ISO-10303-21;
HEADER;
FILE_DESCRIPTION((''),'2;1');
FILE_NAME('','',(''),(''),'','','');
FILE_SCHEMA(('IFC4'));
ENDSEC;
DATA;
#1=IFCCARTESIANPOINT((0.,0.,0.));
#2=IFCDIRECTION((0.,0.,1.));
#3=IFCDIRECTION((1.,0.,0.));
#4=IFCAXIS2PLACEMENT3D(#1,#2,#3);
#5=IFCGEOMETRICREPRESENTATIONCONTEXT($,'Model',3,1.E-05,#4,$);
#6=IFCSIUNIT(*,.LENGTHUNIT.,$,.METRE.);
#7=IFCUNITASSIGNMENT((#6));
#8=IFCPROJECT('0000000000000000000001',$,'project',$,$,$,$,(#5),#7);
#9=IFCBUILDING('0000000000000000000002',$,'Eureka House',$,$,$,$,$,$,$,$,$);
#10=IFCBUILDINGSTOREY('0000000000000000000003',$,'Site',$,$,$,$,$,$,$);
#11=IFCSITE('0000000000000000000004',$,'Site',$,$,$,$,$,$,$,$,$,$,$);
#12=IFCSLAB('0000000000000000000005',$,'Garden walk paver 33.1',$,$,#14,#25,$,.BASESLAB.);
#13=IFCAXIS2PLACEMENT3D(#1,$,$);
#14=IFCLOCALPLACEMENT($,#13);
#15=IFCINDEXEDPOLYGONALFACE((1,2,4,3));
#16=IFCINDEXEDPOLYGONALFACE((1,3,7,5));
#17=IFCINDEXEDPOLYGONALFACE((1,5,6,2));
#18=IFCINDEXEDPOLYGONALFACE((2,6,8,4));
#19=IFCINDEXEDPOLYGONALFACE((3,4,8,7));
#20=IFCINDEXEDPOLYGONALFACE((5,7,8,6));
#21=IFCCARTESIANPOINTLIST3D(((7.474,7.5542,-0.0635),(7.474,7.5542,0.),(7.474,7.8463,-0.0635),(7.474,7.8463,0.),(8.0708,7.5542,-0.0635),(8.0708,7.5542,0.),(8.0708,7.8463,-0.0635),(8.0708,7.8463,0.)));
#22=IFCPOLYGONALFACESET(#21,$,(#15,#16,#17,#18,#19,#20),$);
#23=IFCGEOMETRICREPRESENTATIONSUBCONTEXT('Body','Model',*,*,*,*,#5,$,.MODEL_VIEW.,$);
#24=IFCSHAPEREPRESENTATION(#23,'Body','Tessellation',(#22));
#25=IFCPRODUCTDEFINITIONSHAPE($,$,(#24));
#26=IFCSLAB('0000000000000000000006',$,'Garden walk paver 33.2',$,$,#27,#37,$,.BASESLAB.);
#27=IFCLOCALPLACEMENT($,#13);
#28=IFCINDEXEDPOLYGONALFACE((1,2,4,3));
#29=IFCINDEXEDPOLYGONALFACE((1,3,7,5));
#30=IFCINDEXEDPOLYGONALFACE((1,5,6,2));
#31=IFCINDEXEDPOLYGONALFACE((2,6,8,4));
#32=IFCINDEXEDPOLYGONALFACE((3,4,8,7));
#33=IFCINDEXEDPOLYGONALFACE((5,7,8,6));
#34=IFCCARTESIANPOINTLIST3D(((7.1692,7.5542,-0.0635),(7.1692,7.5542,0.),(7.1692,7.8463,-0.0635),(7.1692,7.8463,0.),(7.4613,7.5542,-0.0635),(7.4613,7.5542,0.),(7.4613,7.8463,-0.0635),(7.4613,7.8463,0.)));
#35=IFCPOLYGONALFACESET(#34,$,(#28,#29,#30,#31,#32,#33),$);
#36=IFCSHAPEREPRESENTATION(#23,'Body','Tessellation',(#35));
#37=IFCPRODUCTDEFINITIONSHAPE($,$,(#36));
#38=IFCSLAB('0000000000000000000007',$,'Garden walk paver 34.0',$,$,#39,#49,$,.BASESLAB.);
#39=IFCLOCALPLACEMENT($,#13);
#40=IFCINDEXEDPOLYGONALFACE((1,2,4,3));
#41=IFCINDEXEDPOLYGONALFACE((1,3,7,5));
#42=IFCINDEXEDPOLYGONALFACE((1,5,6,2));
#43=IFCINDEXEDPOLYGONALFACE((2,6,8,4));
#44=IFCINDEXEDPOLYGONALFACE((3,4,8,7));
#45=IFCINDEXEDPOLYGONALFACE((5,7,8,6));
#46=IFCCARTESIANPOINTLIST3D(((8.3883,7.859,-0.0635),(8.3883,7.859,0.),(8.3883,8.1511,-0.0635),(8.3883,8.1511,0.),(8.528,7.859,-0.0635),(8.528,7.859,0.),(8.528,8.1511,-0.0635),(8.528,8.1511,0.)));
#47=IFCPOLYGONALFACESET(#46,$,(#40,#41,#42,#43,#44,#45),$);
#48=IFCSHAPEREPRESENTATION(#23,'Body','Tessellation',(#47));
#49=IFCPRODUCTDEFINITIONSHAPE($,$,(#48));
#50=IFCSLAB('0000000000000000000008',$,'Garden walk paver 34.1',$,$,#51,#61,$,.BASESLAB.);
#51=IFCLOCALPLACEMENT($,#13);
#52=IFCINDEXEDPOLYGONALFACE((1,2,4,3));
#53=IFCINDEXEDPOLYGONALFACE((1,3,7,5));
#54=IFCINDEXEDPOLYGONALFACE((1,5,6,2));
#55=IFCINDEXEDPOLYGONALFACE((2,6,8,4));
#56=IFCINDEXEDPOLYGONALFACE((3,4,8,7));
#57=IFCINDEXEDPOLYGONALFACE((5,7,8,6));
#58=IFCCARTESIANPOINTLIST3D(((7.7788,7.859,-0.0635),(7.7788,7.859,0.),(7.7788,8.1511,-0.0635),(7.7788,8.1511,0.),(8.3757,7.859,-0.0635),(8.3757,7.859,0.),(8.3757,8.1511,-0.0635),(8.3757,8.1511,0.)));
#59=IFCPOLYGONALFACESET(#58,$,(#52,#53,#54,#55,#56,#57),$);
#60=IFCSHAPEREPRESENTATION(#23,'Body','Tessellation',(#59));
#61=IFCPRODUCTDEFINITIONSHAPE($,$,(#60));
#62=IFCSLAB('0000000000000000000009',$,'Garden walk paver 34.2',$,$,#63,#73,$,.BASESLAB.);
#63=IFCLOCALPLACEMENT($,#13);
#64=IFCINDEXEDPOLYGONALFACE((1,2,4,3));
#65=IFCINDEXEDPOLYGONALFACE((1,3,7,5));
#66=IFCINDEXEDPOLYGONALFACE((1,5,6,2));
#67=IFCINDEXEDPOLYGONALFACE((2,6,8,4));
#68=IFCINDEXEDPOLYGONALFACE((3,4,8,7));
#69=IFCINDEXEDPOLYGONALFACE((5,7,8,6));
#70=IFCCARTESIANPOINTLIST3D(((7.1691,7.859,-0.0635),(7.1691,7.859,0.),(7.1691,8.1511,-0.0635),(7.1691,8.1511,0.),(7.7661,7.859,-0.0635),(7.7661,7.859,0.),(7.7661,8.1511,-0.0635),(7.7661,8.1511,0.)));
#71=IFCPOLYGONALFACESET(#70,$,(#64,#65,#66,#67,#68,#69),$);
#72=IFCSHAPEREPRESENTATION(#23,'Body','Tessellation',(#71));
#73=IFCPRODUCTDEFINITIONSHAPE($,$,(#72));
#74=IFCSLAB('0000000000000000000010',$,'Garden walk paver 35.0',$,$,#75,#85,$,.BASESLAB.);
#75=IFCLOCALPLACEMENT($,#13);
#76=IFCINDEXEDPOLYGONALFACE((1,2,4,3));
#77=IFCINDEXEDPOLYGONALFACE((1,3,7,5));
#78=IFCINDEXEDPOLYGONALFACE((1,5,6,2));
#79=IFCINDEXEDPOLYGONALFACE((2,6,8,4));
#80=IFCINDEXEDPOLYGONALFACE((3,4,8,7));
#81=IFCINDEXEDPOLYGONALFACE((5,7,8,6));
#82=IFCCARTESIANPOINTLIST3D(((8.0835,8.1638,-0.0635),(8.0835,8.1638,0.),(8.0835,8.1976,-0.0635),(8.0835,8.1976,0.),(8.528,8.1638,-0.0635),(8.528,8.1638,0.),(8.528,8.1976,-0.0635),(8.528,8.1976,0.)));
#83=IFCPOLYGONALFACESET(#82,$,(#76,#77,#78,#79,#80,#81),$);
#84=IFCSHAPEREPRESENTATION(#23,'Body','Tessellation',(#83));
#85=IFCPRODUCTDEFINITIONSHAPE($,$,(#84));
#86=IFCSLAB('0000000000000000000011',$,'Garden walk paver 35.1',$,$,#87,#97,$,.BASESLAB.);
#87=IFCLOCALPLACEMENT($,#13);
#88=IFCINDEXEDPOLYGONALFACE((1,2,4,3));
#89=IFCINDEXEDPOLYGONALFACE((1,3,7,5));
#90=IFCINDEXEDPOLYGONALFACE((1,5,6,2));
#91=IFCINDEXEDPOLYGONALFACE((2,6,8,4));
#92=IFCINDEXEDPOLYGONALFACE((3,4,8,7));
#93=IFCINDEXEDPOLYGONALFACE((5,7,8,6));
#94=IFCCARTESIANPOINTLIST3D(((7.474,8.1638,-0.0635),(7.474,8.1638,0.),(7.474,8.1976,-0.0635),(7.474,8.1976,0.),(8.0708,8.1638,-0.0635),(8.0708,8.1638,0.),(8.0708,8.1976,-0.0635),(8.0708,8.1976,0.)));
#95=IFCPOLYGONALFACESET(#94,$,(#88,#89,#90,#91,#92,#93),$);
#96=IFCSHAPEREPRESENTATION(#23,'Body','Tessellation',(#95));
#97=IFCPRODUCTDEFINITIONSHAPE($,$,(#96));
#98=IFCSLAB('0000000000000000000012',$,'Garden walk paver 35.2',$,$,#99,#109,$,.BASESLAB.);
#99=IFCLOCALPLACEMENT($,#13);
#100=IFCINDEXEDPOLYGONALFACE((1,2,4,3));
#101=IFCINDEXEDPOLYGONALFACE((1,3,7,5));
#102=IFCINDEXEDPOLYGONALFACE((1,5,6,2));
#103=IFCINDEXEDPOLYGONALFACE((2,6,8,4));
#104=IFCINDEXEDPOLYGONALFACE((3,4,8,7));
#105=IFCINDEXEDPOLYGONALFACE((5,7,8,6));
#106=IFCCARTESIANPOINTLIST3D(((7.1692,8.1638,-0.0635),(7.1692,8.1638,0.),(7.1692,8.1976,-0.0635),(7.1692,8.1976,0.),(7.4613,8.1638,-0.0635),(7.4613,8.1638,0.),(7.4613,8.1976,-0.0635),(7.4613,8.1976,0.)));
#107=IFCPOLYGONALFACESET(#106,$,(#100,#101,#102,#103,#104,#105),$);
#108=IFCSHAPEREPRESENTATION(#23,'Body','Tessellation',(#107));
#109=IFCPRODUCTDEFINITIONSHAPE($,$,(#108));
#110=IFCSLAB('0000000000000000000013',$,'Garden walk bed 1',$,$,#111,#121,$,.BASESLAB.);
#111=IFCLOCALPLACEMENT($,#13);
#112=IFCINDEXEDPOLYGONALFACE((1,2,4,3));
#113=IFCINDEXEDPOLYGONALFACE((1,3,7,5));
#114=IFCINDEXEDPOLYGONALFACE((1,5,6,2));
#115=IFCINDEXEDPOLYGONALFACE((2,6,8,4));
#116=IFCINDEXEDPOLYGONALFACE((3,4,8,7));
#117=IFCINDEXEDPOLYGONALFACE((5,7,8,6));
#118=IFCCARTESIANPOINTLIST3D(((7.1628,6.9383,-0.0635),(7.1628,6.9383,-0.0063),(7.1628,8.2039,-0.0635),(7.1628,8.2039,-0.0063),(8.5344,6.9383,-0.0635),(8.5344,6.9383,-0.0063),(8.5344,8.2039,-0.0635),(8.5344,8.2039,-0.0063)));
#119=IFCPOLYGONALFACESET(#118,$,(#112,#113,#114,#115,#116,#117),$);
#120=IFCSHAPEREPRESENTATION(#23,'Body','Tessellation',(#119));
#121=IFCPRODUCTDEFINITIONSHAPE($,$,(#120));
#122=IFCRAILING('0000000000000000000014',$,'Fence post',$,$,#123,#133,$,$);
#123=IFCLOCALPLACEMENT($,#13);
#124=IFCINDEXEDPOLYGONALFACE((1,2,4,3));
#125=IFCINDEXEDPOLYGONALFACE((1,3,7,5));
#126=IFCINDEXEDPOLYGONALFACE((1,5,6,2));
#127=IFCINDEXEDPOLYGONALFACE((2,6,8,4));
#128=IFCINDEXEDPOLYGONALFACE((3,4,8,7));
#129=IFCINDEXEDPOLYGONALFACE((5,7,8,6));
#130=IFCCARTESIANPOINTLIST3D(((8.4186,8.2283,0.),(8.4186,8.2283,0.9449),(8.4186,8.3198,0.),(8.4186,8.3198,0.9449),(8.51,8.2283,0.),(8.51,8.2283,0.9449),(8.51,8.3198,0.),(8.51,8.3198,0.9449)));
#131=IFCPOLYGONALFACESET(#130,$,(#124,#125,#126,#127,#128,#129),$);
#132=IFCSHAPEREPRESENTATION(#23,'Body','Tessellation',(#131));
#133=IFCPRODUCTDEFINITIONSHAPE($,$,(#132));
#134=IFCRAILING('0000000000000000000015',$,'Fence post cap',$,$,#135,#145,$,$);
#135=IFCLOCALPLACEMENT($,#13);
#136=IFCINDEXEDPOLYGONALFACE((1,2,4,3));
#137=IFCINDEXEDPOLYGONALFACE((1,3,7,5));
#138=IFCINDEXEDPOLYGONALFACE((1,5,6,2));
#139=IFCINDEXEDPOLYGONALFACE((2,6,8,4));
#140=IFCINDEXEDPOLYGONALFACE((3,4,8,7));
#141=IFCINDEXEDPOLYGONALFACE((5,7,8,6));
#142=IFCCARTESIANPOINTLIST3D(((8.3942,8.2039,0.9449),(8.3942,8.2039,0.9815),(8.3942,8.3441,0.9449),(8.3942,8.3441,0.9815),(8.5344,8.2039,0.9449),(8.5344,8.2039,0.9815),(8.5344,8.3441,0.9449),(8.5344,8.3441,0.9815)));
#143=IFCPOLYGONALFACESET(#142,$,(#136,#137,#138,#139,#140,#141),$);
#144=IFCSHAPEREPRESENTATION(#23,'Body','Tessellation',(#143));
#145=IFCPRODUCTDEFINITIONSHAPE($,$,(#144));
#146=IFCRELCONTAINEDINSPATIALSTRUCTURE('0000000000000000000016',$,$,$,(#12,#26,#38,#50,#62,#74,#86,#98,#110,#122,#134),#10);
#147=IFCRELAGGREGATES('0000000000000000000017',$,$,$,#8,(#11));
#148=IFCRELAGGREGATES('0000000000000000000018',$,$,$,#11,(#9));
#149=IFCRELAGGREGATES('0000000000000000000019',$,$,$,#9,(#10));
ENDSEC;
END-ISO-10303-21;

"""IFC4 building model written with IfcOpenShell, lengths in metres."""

from ifc_helpers import new_model, si_unit, frame, origin, origin_with_axes, origin_2d, place, context, subcontext, project, spatial, rectangle, extrude, element, save


model = new_model("IFC4")

# Units and contexts
model_context = context("Model", 3, precision=1e-05, world=origin_with_axes())
body_context = subcontext(model_context, "Body", "Model", "MODEL_VIEW")
ifc_project = project(units=[si_unit("LENGTHUNIT", "METRE")], contexts=[model_context])

# Site, building, storey
site = spatial("IfcSite", under=ifc_project, Name="Site")
building = spatial("IfcBuilding", under=site, Name="Eureka House")
storey = spatial("IfcBuildingStorey", under=building, Name="Site")

# Slabs
slab_1_placement = place(None, frame((7.7724, 7.7003, -0.0635), z_axis=(0.0, 0.0, 1.0), x_axis=(1.0, 0.0, 0.0)))
element("IfcSlab", 1, at=slab_1_placement, inside=storey, Name="Garden walk paver 33.1", PredefinedType="BASESLAB", context=body_context, shape_type="SweptSolid", body=[
    extrude(rectangle(XDim=0.5969, YDim=0.2921, at=origin_2d()), origin(), (0.0, 0.0, 1.0), 0.0635),
])
slab_2_placement = place(None, frame((7.3152, 7.7003, -0.0635), z_axis=(0.0, 0.0, 1.0), x_axis=(1.0, 0.0, 0.0)))
element("IfcSlab", 2, at=slab_2_placement, inside=storey, Name="Garden walk paver 33.2", PredefinedType="BASESLAB", context=body_context, shape_type="SweptSolid", body=[
    extrude(rectangle(XDim=0.2921, YDim=0.2921, at=origin_2d()), origin(), (0.0, 0.0, 1.0), 0.0635),
])
slab_3_placement = place(None, frame((8.4582, 8.0051, -0.0635), z_axis=(0.0, 0.0, 1.0), x_axis=(1.0, 0.0, 0.0)))
element("IfcSlab", 3, at=slab_3_placement, inside=storey, Name="Garden walk paver 34.0", PredefinedType="BASESLAB", context=body_context, shape_type="SweptSolid", body=[
    extrude(rectangle(XDim=0.1397, YDim=0.2921, at=origin_2d()), origin(), (0.0, 0.0, 1.0), 0.0635),
])
for number, where, z_axis, x_axis, name in (
    (4, (8.0772, 8.0051, -0.0635), (0.0, 0.0, 1.0), (1.0, 0.0, 0.0), "Garden walk paver 34.1"),
    (5, (7.4676, 8.0051, -0.0635), (0.0, 0.0, 1.0), (1.0, 0.0, 0.0), "Garden walk paver 34.2"),
):
    element("IfcSlab", number, at=place(None, frame(where, z_axis=z_axis, x_axis=x_axis)), inside=storey, Name=name, PredefinedType="BASESLAB", context=body_context, shape_type="SweptSolid", body=[
        extrude(rectangle(XDim=0.5969, YDim=0.2921, at=origin_2d()), origin(), (0.0, 0.0, 1.0), 0.0635),
    ])
slab_4_placement = place(None, frame((8.3058, 8.1807, -0.0635), z_axis=(0.0, 0.0, 1.0), x_axis=(1.0, 0.0, 0.0)))
element("IfcSlab", 6, at=slab_4_placement, inside=storey, Name="Garden walk paver 35.0", PredefinedType="BASESLAB", context=body_context, shape_type="SweptSolid", body=[
    extrude(rectangle(XDim=0.4445, YDim=0.0338, at=origin_2d()), origin(), (0.0, 0.0, 1.0), 0.0635),
])
slab_5_placement = place(None, frame((7.7724, 8.1807, -0.0635), z_axis=(0.0, 0.0, 1.0), x_axis=(1.0, 0.0, 0.0)))
element("IfcSlab", 7, at=slab_5_placement, inside=storey, Name="Garden walk paver 35.1", PredefinedType="BASESLAB", context=body_context, shape_type="SweptSolid", body=[
    extrude(rectangle(XDim=0.5969, YDim=0.0338, at=origin_2d()), origin(), (0.0, 0.0, 1.0), 0.0635),
])
slab_6_placement = place(None, frame((7.3152, 8.1807, -0.0635), z_axis=(0.0, 0.0, 1.0), x_axis=(1.0, 0.0, 0.0)))
element("IfcSlab", 8, at=slab_6_placement, inside=storey, Name="Garden walk paver 35.2", PredefinedType="BASESLAB", context=body_context, shape_type="SweptSolid", body=[
    extrude(rectangle(XDim=0.2921, YDim=0.0338, at=origin_2d()), origin(), (0.0, 0.0, 1.0), 0.0635),
])
slab_7_placement = place(None, frame((7.8486, 7.5711, -0.0635), z_axis=(0.0, 0.0, 1.0), x_axis=(1.0, 0.0, 0.0)))
element("IfcSlab", 9, at=slab_7_placement, inside=storey, Name="Garden walk bed 1", PredefinedType="BASESLAB", context=body_context, shape_type="SweptSolid", body=[
    extrude(rectangle(XDim=1.3716, YDim=1.2657, at=origin_2d()), origin(), (0.0, 0.0, 1.0), 0.0572),
])

# Railings
railing_1_placement = place(None, frame((8.4643, 8.274, 0.0), z_axis=(0.0, 0.0, 1.0), x_axis=(1.0, 0.0, 0.0)))
element("IfcRailing", 10, at=railing_1_placement, inside=storey, Name="Fence post", context=body_context, shape_type="SweptSolid", body=[
    extrude(rectangle(XDim=0.0914, YDim=0.0914, at=origin_2d()), origin(), (0.0, 0.0, 1.0), 0.9449),
])
railing_2_placement = place(None, frame((8.4643, 8.274, 0.9449), z_axis=(0.0, 0.0, 1.0), x_axis=(1.0, 0.0, 0.0)))
element("IfcRailing", 11, at=railing_2_placement, inside=storey, Name="Fence post cap", context=body_context, shape_type="SweptSolid", body=[
    extrude(rectangle(XDim=0.1402, YDim=0.1402, at=origin_2d()), origin(), (0.0, 0.0, 1.0), 0.0366),
])

save(model, "model.ifc")
